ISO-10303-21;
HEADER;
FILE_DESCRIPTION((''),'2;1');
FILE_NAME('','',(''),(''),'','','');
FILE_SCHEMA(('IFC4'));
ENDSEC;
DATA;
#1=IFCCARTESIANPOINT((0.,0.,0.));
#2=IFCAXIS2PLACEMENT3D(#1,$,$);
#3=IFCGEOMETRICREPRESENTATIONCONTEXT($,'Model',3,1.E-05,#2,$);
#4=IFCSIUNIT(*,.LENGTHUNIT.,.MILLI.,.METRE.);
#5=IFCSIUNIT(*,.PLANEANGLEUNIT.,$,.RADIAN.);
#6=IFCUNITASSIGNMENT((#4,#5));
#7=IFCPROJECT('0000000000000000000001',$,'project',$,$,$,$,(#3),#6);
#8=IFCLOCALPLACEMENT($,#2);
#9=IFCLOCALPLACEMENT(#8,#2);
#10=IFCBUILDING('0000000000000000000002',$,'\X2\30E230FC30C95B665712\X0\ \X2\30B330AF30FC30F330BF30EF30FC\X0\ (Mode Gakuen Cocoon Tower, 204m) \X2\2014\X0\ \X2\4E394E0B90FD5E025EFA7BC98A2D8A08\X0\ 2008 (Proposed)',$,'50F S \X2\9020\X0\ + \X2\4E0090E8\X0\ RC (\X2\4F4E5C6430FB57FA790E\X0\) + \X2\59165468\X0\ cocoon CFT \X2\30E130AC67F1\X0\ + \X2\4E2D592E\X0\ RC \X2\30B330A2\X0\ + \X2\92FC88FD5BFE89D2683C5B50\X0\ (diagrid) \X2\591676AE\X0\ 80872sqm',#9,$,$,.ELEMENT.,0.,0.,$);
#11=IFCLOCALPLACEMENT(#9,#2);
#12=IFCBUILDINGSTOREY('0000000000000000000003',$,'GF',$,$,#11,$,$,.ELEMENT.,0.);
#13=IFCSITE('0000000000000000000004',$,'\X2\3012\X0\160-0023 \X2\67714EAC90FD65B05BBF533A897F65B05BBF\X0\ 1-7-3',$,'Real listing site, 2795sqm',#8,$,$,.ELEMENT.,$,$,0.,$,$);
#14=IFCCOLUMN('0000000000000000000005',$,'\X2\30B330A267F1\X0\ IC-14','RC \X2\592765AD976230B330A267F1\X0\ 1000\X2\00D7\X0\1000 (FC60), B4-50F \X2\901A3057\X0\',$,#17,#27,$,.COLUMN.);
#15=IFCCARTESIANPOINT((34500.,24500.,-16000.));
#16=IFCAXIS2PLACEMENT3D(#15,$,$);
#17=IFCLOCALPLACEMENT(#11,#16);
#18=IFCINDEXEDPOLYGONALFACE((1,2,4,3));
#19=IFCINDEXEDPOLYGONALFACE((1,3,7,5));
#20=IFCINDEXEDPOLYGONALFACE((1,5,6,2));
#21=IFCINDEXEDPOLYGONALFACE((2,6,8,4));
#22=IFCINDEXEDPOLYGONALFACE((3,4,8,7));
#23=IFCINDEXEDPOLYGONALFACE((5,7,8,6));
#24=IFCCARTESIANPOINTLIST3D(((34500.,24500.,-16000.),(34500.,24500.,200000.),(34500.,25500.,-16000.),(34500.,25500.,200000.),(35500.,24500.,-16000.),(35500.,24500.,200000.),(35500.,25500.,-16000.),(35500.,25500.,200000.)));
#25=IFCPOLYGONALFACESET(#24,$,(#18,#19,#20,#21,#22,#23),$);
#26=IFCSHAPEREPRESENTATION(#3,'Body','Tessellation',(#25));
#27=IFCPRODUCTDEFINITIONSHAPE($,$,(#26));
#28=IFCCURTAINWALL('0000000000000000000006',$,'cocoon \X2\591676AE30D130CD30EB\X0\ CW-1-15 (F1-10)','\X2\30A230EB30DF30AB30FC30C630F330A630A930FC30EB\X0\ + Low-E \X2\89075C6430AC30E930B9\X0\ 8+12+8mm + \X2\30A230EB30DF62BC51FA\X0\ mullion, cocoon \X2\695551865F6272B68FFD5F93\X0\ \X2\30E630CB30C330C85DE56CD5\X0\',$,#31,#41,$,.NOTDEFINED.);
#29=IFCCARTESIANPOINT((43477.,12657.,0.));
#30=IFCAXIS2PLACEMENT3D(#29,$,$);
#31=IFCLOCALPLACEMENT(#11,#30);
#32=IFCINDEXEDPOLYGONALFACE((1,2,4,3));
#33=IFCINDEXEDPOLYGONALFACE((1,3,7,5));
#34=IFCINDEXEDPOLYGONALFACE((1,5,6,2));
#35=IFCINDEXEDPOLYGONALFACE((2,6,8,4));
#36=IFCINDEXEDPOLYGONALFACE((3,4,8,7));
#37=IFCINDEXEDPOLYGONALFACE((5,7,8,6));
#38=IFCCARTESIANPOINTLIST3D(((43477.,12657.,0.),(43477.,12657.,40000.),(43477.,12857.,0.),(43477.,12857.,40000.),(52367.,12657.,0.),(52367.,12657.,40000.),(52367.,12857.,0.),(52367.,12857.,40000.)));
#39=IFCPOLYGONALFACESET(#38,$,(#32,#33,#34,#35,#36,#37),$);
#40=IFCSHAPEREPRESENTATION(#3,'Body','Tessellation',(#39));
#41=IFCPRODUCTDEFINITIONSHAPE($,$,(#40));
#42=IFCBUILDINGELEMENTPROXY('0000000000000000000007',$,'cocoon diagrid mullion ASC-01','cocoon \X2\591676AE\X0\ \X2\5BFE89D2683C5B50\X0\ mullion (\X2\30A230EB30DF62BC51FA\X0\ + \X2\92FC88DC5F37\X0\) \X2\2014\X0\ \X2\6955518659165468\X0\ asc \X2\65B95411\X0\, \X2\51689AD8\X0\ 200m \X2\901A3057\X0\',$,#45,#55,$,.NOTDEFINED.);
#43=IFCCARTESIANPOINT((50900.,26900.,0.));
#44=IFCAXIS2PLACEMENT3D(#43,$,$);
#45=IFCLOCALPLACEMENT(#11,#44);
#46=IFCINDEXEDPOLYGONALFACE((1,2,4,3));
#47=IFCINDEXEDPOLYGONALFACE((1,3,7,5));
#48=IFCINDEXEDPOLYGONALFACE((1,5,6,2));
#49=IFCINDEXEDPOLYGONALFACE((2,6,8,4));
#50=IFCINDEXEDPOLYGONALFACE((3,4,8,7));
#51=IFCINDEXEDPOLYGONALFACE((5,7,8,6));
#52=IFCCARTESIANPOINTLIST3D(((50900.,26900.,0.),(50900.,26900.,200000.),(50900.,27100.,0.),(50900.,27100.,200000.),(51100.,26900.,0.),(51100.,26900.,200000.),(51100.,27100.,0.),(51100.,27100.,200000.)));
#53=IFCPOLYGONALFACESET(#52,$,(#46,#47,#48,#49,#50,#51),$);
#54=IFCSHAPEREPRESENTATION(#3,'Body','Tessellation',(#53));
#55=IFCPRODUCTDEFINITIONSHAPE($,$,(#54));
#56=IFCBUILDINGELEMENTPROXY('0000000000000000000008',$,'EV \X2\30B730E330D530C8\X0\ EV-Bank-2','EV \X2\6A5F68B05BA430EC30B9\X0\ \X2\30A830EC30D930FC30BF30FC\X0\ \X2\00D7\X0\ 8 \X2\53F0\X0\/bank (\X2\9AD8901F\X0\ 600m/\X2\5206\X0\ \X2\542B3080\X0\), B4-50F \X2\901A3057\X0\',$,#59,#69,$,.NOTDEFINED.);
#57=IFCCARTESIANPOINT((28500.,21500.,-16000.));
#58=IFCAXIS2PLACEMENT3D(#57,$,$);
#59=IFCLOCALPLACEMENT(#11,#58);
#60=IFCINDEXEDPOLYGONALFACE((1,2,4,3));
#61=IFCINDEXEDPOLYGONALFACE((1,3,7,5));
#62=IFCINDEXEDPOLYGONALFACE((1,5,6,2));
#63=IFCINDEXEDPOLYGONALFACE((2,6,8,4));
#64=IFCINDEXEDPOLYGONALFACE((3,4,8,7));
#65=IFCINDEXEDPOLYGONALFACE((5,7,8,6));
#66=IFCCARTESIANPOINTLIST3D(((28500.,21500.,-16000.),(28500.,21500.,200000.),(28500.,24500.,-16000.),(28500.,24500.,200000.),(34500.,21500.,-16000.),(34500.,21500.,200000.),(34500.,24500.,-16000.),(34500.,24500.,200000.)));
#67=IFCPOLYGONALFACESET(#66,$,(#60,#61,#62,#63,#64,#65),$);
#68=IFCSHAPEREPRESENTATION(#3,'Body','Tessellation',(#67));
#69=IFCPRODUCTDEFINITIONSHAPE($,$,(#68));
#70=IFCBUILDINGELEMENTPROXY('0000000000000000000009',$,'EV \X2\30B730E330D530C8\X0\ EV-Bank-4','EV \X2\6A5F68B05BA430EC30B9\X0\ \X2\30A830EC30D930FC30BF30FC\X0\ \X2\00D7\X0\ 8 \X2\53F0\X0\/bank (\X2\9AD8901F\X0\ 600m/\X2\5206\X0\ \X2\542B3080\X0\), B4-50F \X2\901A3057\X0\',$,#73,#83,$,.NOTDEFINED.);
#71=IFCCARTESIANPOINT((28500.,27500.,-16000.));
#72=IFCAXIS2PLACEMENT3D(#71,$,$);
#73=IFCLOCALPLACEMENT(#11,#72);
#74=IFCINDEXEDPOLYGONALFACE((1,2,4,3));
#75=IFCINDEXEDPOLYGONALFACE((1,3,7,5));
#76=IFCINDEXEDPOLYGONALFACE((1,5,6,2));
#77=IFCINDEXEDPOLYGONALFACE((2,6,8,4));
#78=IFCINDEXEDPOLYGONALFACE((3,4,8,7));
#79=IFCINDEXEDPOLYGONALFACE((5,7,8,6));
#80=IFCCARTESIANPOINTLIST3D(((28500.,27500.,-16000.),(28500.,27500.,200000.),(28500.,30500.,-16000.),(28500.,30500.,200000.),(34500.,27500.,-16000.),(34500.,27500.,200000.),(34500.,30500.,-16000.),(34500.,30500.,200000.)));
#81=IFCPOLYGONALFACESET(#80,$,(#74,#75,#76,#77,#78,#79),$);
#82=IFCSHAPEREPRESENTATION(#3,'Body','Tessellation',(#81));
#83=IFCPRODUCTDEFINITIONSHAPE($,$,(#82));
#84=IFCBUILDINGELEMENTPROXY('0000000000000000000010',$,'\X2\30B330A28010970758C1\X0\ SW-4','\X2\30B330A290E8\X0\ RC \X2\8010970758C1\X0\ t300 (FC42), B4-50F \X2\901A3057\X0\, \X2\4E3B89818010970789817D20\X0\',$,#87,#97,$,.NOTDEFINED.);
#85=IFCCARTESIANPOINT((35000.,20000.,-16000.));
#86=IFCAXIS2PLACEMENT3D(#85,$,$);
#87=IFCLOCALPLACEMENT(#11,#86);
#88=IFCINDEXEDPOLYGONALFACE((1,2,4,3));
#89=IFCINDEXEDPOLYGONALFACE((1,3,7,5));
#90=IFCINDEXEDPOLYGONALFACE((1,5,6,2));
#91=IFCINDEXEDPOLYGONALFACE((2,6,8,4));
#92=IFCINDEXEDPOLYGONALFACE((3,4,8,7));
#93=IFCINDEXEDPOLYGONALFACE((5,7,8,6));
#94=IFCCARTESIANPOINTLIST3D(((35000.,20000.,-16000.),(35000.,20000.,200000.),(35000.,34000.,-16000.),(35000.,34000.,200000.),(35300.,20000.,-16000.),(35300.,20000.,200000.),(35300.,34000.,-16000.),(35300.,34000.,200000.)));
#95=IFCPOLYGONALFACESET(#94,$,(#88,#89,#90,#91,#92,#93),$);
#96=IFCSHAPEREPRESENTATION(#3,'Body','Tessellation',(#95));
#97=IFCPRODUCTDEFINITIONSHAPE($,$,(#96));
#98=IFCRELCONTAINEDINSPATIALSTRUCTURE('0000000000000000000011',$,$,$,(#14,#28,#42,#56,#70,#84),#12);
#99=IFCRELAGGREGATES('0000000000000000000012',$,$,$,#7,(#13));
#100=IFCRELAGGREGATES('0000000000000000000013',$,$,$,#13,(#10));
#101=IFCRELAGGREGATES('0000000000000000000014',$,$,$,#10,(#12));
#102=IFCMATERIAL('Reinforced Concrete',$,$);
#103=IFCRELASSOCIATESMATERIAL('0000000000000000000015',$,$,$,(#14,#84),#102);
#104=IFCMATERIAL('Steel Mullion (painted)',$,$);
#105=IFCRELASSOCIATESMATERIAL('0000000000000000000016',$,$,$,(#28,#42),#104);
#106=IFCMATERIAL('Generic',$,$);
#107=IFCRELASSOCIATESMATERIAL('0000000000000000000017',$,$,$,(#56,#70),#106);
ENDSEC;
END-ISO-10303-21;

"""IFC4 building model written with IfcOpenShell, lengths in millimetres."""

from ifc_helpers import new_model, si_unit, frame, frame_2d, origin, place, context, project, spatial, rectangle, extrude, material, element, save


model = new_model("IFC4")

# Units and contexts
model_context = context("Model", 3, precision=1e-05, world=origin())
ifc_project = project(units=[si_unit("LENGTHUNIT", "METRE", prefix="MILLI"), si_unit("PLANEANGLEUNIT", "RADIAN")], contexts=[model_context])

# Site, building, storey
site_placement = place(None, origin())
site = spatial("IfcSite", under=ifc_project, at=site_placement, Name="〒160-0023 東京都新宿区西新宿 1-7-3", ObjectType="Real listing site, 2795sqm", CompositionType="ELEMENT", RefElevation=0.0)
building_placement = place(site_placement, origin())
building = spatial("IfcBuilding", under=site, at=building_placement, Name="モード学園 コクーンタワー (Mode Gakuen Cocoon Tower, 204m) — 丹下都市建築設計 2008 (Proposed)", ObjectType="50F S 造 + 一部 RC (低層・基礎) + 外周 cocoon CFT メガ柱 + 中央 RC コア + 鋼製対角格子 (diagrid) 外皮 80872sqm", CompositionType="ELEMENT", ElevationOfRefHeight=0.0, ElevationOfTerrain=0.0)
storey_placement = place(building_placement, origin())
storey = spatial("IfcBuildingStorey", under=building, at=storey_placement, Name="GF", CompositionType="ELEMENT", Elevation=0.0)

# Shared definitions
ifc_material_1 = material(Name="Reinforced Concrete")

# Column
column_1_placement = place(storey_placement, frame((34500.0, 24500.0, -16000.0)))
element("IfcColumn", 1, at=column_1_placement, inside=storey, material=ifc_material_1, Name="コア柱 IC-14", Description="RC 大断面コア柱 1000×1000 (FC60), B4-50F 通し", PredefinedType="COLUMN", context=model_context, shape_type="SweptSolid", body=[
    extrude(rectangle(XDim=1000.0, YDim=1000.0, at=frame_2d((500.0, 500.0))), frame((34500.0, 24500.0, -16000.0)), (0.0, 0.0, 1.0), 216000.0),
])

# Curtain wall
ifc_material_2 = material(Name="Steel Mullion (painted)")
curtain_wall_1_placement = place(storey_placement, frame((43477.0, 12657.0, 0.0)))
element("IfcCurtainWall", 2, at=curtain_wall_1_placement, inside=storey, material=ifc_material_2, Name="cocoon 外皮パネル CW-1-15 (F1-10)", Description="アルミカーテンウォール + Low-E 複層ガラス 8+12+8mm + アルミ押出 mullion, cocoon 楕円形状追従 ユニット工法", PredefinedType="NOTDEFINED", context=model_context, shape_type="SweptSolid", body=[
    extrude(rectangle(XDim=8890.0, YDim=200.0, at=frame_2d((4445.0, 100.0))), frame((43477.0, 12657.0, 0.0)), (0.0, 0.0, 1.0), 40000.0),
])

# Building element proxies
proxy_1_placement = place(storey_placement, frame((50900.0, 26900.0, 0.0)))
element("IfcBuildingElementProxy", 3, at=proxy_1_placement, inside=storey, material=ifc_material_2, Name="cocoon diagrid mullion ASC-01", Description="cocoon 外皮 対角格子 mullion (アルミ押出 + 鋼補強) — 楕円外周 asc 方向, 全高 200m 通し", PredefinedType="NOTDEFINED", context=model_context, shape_type="SweptSolid", body=[
    extrude(rectangle(XDim=200.0, YDim=200.0, at=frame_2d((100.0, 100.0))), frame((50900.0, 26900.0, 0.0)), (0.0, 0.0, 1.0), 200000.0),
])
ifc_material_3 = material(Name="Generic")
proxy_2_placement = place(storey_placement, frame((28500.0, 21500.0, -16000.0)))
element("IfcBuildingElementProxy", 4, at=proxy_2_placement, inside=storey, material=ifc_material_3, Name="EV シャフト EV-Bank-2", Description="EV 機械室レス エレベーター × 8 台/bank (高速 600m/分 含む), B4-50F 通し", PredefinedType="NOTDEFINED", context=model_context, shape_type="SweptSolid", body=[
    extrude(rectangle(XDim=6000.0, YDim=3000.0, at=frame_2d((3000.0, 1500.0))), frame((28500.0, 21500.0, -16000.0)), (0.0, 0.0, 1.0), 216000.0),
])
proxy_3_placement = place(storey_placement, frame((28500.0, 27500.0, -16000.0)))
element("IfcBuildingElementProxy", 5, at=proxy_3_placement, inside=storey, material=ifc_material_3, Name="EV シャフト EV-Bank-4", Description="EV 機械室レス エレベーター × 8 台/bank (高速 600m/分 含む), B4-50F 通し", PredefinedType="NOTDEFINED", context=model_context, shape_type="SweptSolid", body=[
    extrude(rectangle(XDim=6000.0, YDim=3000.0, at=frame_2d((3000.0, 1500.0))), frame((28500.0, 27500.0, -16000.0)), (0.0, 0.0, 1.0), 216000.0),
])
proxy_4_placement = place(storey_placement, frame((35000.0, 20000.0, -16000.0)))
element("IfcBuildingElementProxy", 6, at=proxy_4_placement, inside=storey, material=ifc_material_1, Name="コア耐震壁 SW-4", Description="コア部 RC 耐震壁 t300 (FC42), B4-50F 通し, 主要耐震要素", PredefinedType="NOTDEFINED", context=model_context, shape_type="SweptSolid", body=[
    extrude(rectangle(XDim=300.0, YDim=14000.0, at=frame_2d((150.0, 7000.0))), frame((35000.0, 20000.0, -16000.0)), (0.0, 0.0, 1.0), 216000.0),
])

save(model, "model.ifc")
